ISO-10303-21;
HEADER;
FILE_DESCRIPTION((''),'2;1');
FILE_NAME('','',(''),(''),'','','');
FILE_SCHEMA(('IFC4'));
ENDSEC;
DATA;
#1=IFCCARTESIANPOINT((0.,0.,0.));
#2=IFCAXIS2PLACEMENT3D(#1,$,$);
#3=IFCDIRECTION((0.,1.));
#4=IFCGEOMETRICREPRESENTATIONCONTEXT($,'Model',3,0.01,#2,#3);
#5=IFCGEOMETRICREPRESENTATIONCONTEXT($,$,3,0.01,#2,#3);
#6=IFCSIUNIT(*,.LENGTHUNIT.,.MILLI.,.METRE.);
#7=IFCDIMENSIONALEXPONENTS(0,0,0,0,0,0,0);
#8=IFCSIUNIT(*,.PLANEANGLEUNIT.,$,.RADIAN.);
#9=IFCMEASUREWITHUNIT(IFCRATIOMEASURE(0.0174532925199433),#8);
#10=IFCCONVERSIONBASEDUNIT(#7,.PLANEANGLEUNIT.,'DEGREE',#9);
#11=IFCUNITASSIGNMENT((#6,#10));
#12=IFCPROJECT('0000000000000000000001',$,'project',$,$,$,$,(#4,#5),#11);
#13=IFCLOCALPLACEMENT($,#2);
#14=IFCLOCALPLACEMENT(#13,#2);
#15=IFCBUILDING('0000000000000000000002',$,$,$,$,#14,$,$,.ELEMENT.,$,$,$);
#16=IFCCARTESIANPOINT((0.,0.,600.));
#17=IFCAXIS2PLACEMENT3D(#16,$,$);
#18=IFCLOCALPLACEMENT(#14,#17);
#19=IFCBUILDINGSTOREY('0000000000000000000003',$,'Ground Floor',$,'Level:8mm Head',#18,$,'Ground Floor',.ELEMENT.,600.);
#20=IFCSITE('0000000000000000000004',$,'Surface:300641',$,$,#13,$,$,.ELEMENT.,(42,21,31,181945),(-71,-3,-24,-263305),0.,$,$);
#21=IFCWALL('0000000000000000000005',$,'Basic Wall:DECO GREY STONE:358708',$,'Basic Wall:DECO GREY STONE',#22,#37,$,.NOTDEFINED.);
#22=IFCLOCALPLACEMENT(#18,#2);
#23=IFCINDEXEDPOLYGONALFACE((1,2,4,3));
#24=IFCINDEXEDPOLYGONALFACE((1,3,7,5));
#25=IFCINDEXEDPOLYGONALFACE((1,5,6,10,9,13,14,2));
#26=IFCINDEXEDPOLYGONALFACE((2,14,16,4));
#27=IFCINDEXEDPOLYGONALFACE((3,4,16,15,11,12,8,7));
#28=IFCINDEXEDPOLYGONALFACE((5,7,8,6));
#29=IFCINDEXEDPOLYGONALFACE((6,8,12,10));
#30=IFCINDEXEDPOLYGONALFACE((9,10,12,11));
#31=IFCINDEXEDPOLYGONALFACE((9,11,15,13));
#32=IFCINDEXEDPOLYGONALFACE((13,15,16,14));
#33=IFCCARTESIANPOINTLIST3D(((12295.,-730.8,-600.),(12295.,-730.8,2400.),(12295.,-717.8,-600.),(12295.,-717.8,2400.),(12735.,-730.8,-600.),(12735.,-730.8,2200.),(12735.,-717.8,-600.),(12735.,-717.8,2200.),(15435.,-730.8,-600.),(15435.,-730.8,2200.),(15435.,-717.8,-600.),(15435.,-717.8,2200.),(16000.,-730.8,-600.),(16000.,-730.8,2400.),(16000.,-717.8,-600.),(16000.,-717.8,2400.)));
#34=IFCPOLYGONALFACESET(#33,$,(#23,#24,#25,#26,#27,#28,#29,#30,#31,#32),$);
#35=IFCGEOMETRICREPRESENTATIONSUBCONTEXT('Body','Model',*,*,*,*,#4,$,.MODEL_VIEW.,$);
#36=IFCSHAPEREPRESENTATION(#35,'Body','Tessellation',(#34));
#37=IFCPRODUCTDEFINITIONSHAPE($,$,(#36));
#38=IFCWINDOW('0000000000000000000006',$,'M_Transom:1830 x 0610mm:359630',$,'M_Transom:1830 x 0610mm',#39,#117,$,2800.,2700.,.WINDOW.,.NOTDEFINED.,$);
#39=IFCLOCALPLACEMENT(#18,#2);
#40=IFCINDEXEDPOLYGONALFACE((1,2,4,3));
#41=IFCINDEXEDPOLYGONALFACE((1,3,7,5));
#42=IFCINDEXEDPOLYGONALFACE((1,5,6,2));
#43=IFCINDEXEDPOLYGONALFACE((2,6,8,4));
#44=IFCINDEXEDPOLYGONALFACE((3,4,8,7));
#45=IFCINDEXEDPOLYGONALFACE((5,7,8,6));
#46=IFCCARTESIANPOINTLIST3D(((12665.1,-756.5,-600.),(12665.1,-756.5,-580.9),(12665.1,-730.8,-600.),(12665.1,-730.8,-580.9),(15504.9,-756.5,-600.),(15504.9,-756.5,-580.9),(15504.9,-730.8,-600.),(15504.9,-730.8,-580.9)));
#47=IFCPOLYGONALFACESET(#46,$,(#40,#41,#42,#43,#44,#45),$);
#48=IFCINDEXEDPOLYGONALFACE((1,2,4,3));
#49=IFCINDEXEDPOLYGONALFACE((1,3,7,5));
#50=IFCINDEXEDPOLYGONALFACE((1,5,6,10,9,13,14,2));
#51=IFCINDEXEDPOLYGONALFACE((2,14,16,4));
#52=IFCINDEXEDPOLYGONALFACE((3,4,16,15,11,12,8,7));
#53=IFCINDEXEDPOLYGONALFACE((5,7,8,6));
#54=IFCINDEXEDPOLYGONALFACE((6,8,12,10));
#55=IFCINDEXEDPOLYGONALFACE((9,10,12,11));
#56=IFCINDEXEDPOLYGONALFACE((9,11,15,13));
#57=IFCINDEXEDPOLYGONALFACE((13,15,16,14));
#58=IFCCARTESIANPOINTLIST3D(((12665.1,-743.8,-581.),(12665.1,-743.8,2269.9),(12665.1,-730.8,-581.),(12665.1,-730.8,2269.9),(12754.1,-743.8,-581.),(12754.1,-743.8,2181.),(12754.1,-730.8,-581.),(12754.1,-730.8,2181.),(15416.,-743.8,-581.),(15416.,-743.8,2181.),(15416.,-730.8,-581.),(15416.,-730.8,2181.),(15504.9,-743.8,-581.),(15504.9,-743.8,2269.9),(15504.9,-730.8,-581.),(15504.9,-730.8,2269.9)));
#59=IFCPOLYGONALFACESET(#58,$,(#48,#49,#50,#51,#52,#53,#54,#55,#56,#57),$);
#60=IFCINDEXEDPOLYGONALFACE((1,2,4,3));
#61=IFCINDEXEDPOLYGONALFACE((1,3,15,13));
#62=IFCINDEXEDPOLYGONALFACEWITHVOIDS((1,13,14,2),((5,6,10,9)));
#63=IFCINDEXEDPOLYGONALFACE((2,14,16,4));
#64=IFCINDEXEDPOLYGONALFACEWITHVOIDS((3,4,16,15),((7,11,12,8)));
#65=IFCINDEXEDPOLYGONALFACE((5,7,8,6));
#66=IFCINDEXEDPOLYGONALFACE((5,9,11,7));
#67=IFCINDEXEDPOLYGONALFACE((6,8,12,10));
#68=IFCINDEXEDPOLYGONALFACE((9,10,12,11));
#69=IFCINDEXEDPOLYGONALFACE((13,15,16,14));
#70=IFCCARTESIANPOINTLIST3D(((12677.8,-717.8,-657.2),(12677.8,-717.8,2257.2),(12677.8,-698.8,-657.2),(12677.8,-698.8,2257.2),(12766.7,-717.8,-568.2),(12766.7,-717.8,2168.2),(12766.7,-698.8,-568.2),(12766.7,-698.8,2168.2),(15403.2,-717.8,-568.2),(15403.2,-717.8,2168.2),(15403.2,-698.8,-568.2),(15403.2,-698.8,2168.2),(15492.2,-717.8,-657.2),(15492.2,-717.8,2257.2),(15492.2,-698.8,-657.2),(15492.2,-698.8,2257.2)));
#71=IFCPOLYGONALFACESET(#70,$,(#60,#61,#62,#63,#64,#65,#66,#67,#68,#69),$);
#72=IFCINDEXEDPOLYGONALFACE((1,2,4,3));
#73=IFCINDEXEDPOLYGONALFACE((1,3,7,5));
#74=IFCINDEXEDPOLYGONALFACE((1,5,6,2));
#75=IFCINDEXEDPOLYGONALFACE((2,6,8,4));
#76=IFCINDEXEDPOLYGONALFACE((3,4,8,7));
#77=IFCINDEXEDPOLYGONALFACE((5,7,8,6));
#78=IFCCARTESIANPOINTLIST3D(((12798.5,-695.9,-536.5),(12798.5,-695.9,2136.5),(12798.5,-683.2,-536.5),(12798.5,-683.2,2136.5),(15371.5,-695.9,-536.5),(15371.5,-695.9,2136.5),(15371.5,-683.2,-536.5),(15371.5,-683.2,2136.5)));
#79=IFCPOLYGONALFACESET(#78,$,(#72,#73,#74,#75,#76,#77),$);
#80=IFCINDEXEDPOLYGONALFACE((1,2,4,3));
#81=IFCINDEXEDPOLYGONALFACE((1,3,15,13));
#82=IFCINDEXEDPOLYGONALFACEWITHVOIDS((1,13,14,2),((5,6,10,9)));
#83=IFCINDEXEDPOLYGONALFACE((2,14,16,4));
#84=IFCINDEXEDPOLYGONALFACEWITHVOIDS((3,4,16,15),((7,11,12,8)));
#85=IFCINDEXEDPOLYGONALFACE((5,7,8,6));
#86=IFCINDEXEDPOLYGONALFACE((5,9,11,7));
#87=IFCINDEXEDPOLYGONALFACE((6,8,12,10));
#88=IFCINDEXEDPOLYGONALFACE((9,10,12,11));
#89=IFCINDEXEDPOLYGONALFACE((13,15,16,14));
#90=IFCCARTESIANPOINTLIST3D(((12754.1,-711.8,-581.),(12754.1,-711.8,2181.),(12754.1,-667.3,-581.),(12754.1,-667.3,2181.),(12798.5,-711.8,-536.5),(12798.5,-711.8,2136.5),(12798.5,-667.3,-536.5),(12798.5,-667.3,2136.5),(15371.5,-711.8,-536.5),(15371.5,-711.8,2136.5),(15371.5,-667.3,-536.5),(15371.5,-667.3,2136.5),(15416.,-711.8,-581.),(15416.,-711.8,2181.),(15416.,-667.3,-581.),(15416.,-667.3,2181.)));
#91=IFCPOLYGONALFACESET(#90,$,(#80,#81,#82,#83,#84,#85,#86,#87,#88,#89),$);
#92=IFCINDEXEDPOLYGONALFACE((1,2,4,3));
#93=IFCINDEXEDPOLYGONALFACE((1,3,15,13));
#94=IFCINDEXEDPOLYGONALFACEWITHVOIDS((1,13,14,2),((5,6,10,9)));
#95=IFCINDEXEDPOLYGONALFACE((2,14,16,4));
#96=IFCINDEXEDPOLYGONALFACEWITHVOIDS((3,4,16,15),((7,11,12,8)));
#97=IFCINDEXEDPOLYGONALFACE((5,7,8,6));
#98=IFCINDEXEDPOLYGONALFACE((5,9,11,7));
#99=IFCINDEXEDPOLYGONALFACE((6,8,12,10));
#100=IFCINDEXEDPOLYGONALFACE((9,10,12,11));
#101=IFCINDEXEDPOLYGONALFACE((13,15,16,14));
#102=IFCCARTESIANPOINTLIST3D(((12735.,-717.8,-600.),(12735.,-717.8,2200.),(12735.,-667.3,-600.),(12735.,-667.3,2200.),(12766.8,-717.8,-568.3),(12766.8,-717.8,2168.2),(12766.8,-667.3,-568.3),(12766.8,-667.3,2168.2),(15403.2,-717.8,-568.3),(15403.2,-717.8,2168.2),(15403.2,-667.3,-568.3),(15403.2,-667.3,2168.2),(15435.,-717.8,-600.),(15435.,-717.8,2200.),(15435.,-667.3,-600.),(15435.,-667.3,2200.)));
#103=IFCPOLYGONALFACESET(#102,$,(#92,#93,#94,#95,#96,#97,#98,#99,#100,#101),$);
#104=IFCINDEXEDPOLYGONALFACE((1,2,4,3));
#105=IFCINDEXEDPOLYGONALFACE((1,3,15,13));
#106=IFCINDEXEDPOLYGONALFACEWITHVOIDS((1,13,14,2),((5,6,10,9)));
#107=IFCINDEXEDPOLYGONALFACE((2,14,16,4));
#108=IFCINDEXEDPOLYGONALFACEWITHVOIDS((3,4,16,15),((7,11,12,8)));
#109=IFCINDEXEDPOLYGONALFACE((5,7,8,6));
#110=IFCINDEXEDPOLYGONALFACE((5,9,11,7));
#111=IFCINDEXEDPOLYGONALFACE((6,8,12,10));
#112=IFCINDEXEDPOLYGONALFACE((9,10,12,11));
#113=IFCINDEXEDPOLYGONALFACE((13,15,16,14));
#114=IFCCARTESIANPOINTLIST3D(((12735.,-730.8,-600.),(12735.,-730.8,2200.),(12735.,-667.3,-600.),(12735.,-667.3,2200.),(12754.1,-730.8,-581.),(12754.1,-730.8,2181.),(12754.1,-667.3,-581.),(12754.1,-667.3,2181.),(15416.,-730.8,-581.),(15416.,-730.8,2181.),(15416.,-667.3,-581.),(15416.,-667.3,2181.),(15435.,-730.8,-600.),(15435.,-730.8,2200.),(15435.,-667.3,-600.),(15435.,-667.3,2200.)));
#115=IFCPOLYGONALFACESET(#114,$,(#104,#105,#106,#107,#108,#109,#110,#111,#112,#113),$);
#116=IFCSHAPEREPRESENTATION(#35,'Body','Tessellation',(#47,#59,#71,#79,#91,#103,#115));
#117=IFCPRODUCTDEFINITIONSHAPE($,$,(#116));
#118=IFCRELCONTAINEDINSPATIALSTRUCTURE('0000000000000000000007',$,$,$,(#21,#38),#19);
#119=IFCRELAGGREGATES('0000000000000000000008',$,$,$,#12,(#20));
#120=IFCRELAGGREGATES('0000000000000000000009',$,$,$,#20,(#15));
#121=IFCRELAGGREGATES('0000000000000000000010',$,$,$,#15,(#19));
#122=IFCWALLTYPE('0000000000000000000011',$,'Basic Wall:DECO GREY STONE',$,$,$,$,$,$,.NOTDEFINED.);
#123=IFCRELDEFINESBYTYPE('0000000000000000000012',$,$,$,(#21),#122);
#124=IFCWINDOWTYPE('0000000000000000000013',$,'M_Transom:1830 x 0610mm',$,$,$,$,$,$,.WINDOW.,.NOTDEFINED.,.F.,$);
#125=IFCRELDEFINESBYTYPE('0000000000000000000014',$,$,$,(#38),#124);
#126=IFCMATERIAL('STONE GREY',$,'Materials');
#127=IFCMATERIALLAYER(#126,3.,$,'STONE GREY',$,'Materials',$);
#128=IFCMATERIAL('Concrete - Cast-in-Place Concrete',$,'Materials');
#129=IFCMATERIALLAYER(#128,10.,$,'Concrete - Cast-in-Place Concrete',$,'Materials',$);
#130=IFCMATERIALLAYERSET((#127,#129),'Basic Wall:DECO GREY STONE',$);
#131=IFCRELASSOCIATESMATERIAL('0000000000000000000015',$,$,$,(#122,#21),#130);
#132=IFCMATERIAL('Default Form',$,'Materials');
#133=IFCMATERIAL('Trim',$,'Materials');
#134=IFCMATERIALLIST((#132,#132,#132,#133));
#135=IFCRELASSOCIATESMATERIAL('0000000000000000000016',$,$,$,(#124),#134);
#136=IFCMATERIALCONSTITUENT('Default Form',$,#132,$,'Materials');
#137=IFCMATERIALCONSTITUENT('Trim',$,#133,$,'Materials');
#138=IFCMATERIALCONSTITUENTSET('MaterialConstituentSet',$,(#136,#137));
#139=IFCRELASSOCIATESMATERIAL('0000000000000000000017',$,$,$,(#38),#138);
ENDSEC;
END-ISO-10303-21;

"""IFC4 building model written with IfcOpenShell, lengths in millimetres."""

from ifc_helpers import new_model, entity, si_unit, converted_unit, direction, frame, frame_2d, origin, place, context, subcontext, project, spatial, polyline, rectangle, outline, extrude, source, transform, mapped, material, material_list, layer, layer_set, layer_usage, constituent, constituent_set, type_object, type_shapes, element, fill, save


model = new_model("IFC4")

# Units and contexts
model_context = context("Model", 3, precision=0.01, world=origin(), true_north=direction((0.0, 1.0)))
context_of_model = context(None, 3, precision=0.01, world=origin(), true_north=direction((0.0, 1.0)))
body_context = subcontext(model_context, "Body", "Model", "MODEL_VIEW")
ifc_project = project(units=[si_unit("LENGTHUNIT", "METRE", prefix="MILLI"), converted_unit("PLANEANGLEUNIT", "DEGREE", entity("IfcRatioMeasure", 0.0174532925199433), si_unit("PLANEANGLEUNIT", "RADIAN"), dimensions=[0, 0, 0, 0, 0, 0, 0])], contexts=[model_context, context_of_model])

# Site, building, storey
site_placement = place(None, origin())
site = spatial("IfcSite", under=ifc_project, at=site_placement, Name="Surface:300641", CompositionType="ELEMENT", RefLatitude=(42, 21, 31, 181945), RefLongitude=(-71, -3, -24, -263305), RefElevation=0.0)
building_placement = place(site_placement, origin())
building = spatial("IfcBuilding", under=site, at=building_placement, CompositionType="ELEMENT")
storey_placement = place(building_placement, frame((0.0, 0.0, 600.0)))
storey = spatial("IfcBuildingStorey", under=building, at=storey_placement, Name="Ground Floor", ObjectType="Level:8mm Head", LongName="Ground Floor", CompositionType="ELEMENT", Elevation=600.0)

# Shared definitions
ifc_material_1 = material(Name="Concrete - Cast-in-Place Concrete", Category="Materials")

# Wall, opening, window
ifc_material_2 = material(Name="STONE GREY", Category="Materials")
ifc_layer_1 = layer(ifc_material_2, 3.0, Name="STONE GREY", Category="Materials")
ifc_layer_2 = layer(ifc_material_1, 10.0, Name="Concrete - Cast-in-Place Concrete", Category="Materials")
ifc_layer_set_1 = layer_set([ifc_layer_1, ifc_layer_2], Name="Basic Wall:DECO GREY STONE")
ifc_layer_usage_1 = layer_usage(ifc_layer_set_1, "AXIS2", "POSITIVE", -6.5)
wall_type_1 = type_object("IfcWallType", Name="Basic Wall:DECO GREY STONE", PredefinedType="NOTDEFINED", material=ifc_layer_set_1)
wall_1_placement = place(storey_placement, frame((12295.0, -724.3, -600.0)))
wall_1 = element("IfcWall", 1, at=wall_1_placement, inside=storey, type_object=wall_type_1, material=ifc_layer_usage_1, Name="Basic Wall:DECO GREY STONE:358708", ObjectType="Basic Wall:DECO GREY STONE", PredefinedType="NOTDEFINED", context=body_context, shape_type="SweptSolid", body=[
    extrude(rectangle(XDim=3705.0, YDim=13.0, at=frame_2d((1852.5, 0.0), x_axis=(-1.0, 0.0))), origin(), (0.0, 0.0, 1.0), 3000.0),
])
opening_1_placement = place(wall_1_placement, frame((3140.0, 6.5, 0.0)))
opening_1 = element("IfcOpeningElement", 2, at=opening_1_placement, cuts=wall_1, ObjectType="Opening", PredefinedType="OPENING", context=body_context, shape_type="SweptSolid", body=[
    extrude(rectangle(XDim=2800.0, YDim=2700.0, at=frame_2d((1400.0, 1350.0), x_axis=(-1.0, 0.0))), frame((0.0, 0.0, 0.0), z_axis=(0.0, -1.0, 0.0), x_axis=(0.0, 0.0, 1.0)), (0.0, 0.0, 1.0), 13.0),
])
ifc_material_3 = material(Name="Default Form", Category="Materials")
ifc_constituent_1 = constituent(ifc_material_3, Name="Default Form", Category="Materials")
ifc_material_4 = material(Name="Trim", Category="Materials")
ifc_constituent_2 = constituent(ifc_material_4, Name="Trim", Category="Materials")
ifc_constituent_set = constituent_set(constituents=[ifc_constituent_1, ifc_constituent_2], Name="MaterialConstituentSet")
ifc_material_list = material_list([ifc_material_3, ifc_material_3, ifc_material_3, ifc_material_4])
window_type = type_object("IfcWindowType", Name="M_Transom:1830 x 0610mm", ParameterTakesPrecedence=False, PartitioningType="NOTDEFINED", PredefinedType="WINDOW", material=ifc_material_list)
shared_shape_1 = source(origin(), body_context, "Body", "SweptSolid", [
    extrude(rectangle(XDim=25.7, YDim=2839.9, at=frame_2d((0.0, 0.0), x_axis=(1.0, 0.0))), frame((1350.0, 25.9, 0.0), z_axis=(0.0, 0.0, 1.0), x_axis=(0.0, -1.0, 0.0)), (0.0, 0.0, 1.0), 19.1),
    extrude(outline(polyline([(-1358.7, 1331.0), (1403.2, 1331.0), (1403.2, 1419.9), (-1447.7, 1419.9), (-1447.7, -1419.9), (1403.2, -1419.9), (1403.2, -1330.9), (-1358.7, -1330.9), (-1358.7, 1331.0)])), frame((1350.0, 13.0, 1422.2), z_axis=(0.0, 1.0, 0.0), x_axis=(0.0, 0.0, -1.0)), (0.0, 0.0, 1.0), 13.0),
    extrude(outline(polyline([(-1457.2, -1407.2), (1457.2, -1407.2), (1457.2, 1407.2), (-1457.2, 1407.2), (-1457.2, -1407.2)]), holes=[polyline([(-1368.2, -1318.3), (-1368.2, 1318.2), (1368.2, 1318.2), (1368.2, -1318.3), (-1368.2, -1318.3)])]), frame((1350.0, -19.0, 1400.0), z_axis=(0.0, 1.0, 0.0), x_axis=(0.0, 0.0, -1.0)), (0.0, 0.0, 1.0), 19.0),
    extrude(rectangle(XDim=12.7, YDim=2573.0, at=frame_2d((0.0, 0.0), x_axis=(1.0, 0.0))), frame((1350.0, -28.2, 63.5), z_axis=(0.0, 0.0, 1.0), x_axis=(0.0, 1.0, 0.0)), (0.0, 0.0, 1.0), 2673.0),
    extrude(outline(polyline([(-1331.0, -1381.0), (1331.0, -1381.0), (1331.0, 1381.0), (-1331.0, 1381.0), (-1331.0, -1381.0)]), holes=[polyline([(-1286.5, -1336.5), (-1286.5, 1336.5), (1286.5, 1336.5), (1286.5, -1336.5), (-1286.5, -1336.5)])]), frame((1350.0, -50.5, 1400.0), z_axis=(0.0, 1.0, 0.0), x_axis=(1.0, 0.0, 0.0)), (0.0, 0.0, 1.0), 44.5),
    extrude(outline(polyline([(-1350.0, -1400.0), (1350.0, -1400.0), (1350.0, 1400.0), (-1350.0, 1400.0), (-1350.0, -1400.0)]), holes=[polyline([(-1318.2, -1368.2), (-1318.2, 1368.3), (1318.2, 1368.3), (1318.2, -1368.2), (-1318.2, -1368.2)])]), frame((1350.0, -50.5, 1400.0), z_axis=(0.0, 1.0, 0.0), x_axis=(1.0, 0.0, 0.0)), (0.0, 0.0, 1.0), 50.5),
    extrude(outline(polyline([(-1400.0, -1350.0), (1400.0, -1350.0), (1400.0, 1350.0), (-1400.0, 1350.0), (-1400.0, -1350.0)]), holes=[polyline([(-1381.0, -1331.0), (-1381.0, 1331.0), (1381.0, 1331.0), (1381.0, -1331.0), (-1381.0, -1331.0)])]), frame((1350.0, -50.5, 1400.0), z_axis=(0.0, 1.0, 0.0), x_axis=(0.0, 0.0, -1.0)), (0.0, 0.0, 1.0), 63.5),
])
type_shapes(window_type, [shared_shape_1])
window_placement = place(opening_1_placement, frame((0.0, 0.0, 0.0), z_axis=(0.0, 0.0, 1.0), x_axis=(-1.0, 0.0, 0.0)))
window = element("IfcWindow", 3, at=window_placement, inside=storey, type_object=window_type, material=ifc_constituent_set, Name="M_Transom:1830 x 0610mm:359630", ObjectType="M_Transom:1830 x 0610mm", OverallHeight=2800.0, OverallWidth=2700.0, PartitioningType="NOTDEFINED", PredefinedType="WINDOW", context=body_context, shape_type="MappedRepresentation", body=[
    mapped(shared_shape_1, transform((0.0, 0.0, 0.0), scale=1.0)),
])
fill(opening_1, window)

save(model, "model.ifc")
